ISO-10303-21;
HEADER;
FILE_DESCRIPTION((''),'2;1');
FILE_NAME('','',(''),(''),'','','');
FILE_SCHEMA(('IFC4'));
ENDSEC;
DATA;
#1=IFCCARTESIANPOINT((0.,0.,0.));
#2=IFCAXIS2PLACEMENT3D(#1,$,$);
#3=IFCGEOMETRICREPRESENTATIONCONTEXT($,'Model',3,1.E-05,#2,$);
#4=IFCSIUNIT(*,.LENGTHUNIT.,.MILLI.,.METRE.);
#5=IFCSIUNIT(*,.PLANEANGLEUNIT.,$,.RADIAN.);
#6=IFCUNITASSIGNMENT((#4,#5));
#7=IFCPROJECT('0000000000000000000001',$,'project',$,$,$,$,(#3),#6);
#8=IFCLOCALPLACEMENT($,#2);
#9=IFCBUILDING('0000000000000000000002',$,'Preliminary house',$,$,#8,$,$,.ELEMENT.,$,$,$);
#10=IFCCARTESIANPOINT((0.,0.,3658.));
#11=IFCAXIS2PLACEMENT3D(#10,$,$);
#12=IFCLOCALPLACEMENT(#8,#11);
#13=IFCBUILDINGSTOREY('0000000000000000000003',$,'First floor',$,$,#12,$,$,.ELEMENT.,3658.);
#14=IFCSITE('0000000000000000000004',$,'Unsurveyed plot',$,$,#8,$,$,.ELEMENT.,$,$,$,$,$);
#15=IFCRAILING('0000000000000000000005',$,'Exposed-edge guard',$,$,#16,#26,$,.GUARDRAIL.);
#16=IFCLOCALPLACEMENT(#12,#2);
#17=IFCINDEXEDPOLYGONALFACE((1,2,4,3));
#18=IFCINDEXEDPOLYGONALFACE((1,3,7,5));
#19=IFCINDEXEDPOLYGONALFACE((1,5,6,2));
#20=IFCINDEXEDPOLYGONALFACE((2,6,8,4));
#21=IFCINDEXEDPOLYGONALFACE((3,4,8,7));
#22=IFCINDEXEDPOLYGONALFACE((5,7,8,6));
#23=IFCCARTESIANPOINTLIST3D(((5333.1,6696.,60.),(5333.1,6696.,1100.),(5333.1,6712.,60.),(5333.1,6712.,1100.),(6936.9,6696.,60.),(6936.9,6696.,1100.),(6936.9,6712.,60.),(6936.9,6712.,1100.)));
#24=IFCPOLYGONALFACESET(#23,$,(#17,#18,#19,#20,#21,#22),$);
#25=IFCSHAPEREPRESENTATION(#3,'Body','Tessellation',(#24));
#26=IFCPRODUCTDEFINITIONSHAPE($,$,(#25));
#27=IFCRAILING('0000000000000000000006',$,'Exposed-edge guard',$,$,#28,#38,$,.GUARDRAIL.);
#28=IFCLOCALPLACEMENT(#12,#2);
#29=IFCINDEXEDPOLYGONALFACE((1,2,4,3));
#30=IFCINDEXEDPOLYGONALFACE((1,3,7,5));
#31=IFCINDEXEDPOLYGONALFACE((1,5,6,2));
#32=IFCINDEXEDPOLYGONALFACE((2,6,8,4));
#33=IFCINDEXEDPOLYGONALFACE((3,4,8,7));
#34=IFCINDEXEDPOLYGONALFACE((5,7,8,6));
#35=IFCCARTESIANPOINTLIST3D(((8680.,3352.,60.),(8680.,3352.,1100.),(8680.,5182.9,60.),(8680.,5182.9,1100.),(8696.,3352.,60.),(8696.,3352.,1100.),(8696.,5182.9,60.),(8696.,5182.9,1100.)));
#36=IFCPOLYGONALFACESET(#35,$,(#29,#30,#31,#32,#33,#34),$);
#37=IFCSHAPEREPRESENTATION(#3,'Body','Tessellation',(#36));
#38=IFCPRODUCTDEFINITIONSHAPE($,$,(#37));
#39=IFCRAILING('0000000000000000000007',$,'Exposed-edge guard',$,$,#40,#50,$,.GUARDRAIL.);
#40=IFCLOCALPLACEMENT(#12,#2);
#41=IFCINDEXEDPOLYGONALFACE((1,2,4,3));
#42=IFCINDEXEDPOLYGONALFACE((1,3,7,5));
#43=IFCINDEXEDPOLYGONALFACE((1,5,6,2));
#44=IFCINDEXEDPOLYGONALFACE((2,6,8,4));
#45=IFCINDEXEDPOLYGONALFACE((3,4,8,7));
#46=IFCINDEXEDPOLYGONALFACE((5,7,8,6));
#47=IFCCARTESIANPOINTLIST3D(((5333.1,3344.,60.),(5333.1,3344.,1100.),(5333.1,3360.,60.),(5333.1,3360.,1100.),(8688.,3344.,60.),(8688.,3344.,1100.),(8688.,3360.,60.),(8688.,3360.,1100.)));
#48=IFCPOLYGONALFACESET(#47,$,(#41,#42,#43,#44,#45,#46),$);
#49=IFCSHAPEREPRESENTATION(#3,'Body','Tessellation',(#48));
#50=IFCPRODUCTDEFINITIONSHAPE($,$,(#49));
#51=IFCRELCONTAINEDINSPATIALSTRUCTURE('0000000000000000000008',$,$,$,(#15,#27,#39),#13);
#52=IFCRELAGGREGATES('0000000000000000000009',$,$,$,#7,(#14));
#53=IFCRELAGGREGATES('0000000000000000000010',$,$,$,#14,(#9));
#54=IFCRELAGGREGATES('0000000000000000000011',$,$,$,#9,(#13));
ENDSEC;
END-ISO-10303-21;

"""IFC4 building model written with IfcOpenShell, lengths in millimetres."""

from ifc_helpers import new_model, si_unit, frame, origin, place, context, project, spatial, polyline, outline, extrude, element, save


model = new_model("IFC4")

# Units and contexts
model_context = context("Model", 3, precision=1e-05, world=origin())
ifc_project = project(units=[si_unit("LENGTHUNIT", "METRE", prefix="MILLI"), si_unit("PLANEANGLEUNIT", "RADIAN")], contexts=[model_context])

# Site, building, storey
placement_1 = place(None, origin())
site = spatial("IfcSite", under=ifc_project, at=placement_1, Name="Unsurveyed plot", CompositionType="ELEMENT")
building = spatial("IfcBuilding", under=site, at=placement_1, Name="Preliminary house", CompositionType="ELEMENT")
placement_2 = place(placement_1, frame((0.0, 0.0, 3658.0)))
storey = spatial("IfcBuildingStorey", under=building, at=placement_2, Name="First floor", CompositionType="ELEMENT", Elevation=3658.0)

# Railings
element("IfcRailing", 1, at=placement_2, inside=storey, Name="Exposed-edge guard", PredefinedType="GUARDRAIL", context=model_context, shape_type="SweptSolid", body=[
    extrude(outline(polyline([(6936.9, 6712.0), (6936.9, 6696.0), (5333.1, 6696.0), (5333.1, 6712.0), (6936.9, 6712.0)])), frame((0.0, 0.0, 60.0)), (0.0, 0.0, 1.0), 1040.0),
])
element("IfcRailing", 2, at=placement_2, inside=storey, Name="Exposed-edge guard", PredefinedType="GUARDRAIL", context=model_context, shape_type="SweptSolid", body=[
    extrude(outline(polyline([(8680.0, 5182.9), (8696.0, 5182.9), (8696.0, 3352.0), (8680.0, 3352.0), (8680.0, 5182.9)])), frame((0.0, 0.0, 60.0)), (0.0, 0.0, 1.0), 1040.0),
])
element("IfcRailing", 3, at=placement_2, inside=storey, Name="Exposed-edge guard", PredefinedType="GUARDRAIL", context=model_context, shape_type="SweptSolid", body=[
    extrude(outline(polyline([(8688.0, 3360.0), (8688.0, 3344.0), (5333.1, 3344.0), (5333.1, 3360.0), (8688.0, 3360.0)])), frame((0.0, 0.0, 60.0)), (0.0, 0.0, 1.0), 1040.0),
])

save(model, "model.ifc")
